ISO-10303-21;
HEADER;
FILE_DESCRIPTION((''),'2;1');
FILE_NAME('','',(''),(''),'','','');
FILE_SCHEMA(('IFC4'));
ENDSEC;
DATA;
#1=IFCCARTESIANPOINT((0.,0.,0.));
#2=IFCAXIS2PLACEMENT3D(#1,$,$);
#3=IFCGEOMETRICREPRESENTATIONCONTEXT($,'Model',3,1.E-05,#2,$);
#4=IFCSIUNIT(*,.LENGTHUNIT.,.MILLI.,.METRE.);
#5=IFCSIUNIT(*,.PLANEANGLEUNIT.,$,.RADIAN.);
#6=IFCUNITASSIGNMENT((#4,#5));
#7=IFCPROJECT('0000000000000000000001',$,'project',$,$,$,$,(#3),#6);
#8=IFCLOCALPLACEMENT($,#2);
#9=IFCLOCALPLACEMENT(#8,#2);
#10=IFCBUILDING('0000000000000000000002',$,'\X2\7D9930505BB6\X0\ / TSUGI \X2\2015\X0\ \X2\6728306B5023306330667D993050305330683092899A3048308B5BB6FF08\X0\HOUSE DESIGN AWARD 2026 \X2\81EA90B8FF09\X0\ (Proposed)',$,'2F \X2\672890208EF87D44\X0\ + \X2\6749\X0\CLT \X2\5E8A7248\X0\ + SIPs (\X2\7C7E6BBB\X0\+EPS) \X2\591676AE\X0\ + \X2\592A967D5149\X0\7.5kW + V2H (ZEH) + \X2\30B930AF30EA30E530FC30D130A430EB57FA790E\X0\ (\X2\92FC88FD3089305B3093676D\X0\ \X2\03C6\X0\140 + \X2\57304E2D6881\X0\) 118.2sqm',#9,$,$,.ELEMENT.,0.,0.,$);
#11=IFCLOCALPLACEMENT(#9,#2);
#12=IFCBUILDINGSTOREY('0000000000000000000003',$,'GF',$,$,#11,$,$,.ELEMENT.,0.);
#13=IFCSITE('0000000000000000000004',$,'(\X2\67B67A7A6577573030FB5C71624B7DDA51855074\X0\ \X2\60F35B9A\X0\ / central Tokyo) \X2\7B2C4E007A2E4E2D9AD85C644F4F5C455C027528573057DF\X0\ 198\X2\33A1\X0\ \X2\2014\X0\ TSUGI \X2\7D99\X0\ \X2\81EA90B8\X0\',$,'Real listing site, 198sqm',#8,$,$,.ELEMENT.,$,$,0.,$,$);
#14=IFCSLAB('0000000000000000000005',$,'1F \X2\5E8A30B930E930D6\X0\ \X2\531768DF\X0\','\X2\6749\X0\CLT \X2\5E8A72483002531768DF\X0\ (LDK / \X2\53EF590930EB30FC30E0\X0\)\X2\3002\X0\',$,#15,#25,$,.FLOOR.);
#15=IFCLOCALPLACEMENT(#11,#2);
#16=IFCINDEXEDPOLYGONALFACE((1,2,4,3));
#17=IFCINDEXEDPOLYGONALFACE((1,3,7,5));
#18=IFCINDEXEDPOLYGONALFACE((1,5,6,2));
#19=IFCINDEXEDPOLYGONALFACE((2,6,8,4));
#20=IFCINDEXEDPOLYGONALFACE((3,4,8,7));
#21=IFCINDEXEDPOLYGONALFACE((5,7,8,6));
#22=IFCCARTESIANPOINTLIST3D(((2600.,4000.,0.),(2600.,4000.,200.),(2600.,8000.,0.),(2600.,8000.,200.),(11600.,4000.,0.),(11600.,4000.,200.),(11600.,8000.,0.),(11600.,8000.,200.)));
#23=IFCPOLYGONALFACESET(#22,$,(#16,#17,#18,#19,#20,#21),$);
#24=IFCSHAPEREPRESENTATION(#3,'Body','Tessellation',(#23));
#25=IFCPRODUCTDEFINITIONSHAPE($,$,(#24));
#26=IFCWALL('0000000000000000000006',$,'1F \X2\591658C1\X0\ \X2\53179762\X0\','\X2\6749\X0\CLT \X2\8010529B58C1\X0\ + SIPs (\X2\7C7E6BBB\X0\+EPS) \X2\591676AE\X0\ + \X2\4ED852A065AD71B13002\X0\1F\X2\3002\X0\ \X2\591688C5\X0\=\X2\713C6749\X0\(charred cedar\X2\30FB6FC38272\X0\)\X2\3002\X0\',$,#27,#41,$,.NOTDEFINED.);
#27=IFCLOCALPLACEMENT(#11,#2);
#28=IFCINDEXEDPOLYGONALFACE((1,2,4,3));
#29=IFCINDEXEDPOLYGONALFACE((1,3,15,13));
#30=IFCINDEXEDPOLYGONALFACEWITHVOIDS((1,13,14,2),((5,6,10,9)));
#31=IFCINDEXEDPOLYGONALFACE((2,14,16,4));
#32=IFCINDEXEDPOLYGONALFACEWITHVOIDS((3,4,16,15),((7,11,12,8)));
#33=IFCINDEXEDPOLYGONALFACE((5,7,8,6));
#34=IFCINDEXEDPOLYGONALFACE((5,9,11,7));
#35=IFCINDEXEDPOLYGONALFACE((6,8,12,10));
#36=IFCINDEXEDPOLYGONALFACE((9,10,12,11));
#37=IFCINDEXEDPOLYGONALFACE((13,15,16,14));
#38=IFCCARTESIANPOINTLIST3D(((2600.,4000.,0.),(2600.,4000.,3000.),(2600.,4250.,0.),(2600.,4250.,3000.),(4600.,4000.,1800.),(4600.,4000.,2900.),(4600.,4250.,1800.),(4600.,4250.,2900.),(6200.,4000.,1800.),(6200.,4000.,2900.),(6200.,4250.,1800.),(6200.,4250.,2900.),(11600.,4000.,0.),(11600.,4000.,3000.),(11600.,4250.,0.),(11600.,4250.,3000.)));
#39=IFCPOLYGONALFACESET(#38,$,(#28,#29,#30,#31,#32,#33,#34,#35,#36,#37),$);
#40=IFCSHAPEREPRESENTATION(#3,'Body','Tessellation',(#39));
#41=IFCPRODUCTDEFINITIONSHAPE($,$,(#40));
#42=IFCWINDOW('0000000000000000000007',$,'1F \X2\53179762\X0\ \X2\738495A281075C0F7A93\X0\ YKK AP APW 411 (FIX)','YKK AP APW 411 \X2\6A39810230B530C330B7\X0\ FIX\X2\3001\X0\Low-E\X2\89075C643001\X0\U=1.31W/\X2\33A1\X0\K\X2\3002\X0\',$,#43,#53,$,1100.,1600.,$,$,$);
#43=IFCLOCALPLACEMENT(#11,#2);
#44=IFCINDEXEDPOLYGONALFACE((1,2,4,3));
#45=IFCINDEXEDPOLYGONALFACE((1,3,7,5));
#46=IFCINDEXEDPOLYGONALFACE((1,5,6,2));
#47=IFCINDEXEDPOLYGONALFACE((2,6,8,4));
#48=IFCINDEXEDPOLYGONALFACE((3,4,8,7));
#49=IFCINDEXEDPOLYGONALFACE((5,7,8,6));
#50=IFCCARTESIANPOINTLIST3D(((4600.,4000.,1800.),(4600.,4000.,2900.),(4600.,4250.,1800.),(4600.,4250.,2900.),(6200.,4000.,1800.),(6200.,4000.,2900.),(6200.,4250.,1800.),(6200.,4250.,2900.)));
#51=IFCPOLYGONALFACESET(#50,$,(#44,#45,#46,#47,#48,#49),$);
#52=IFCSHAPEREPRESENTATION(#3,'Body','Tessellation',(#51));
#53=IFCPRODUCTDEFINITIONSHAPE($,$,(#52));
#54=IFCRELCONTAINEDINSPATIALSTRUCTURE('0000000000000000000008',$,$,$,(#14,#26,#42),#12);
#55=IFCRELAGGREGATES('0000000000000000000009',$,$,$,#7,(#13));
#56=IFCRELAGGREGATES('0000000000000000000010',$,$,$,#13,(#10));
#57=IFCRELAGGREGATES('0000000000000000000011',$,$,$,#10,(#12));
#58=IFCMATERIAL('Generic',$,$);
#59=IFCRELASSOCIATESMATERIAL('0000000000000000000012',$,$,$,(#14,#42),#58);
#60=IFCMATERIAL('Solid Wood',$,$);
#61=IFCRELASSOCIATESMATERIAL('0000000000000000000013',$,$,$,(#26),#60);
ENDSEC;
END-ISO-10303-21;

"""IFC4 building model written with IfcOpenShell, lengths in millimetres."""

from ifc_helpers import new_model, si_unit, frame, frame_2d, origin, place, context, project, spatial, rectangle, extrude, material, element, fill, save


model = new_model("IFC4")

# Units and contexts
model_context = context("Model", 3, precision=1e-05, world=origin())
ifc_project = project(units=[si_unit("LENGTHUNIT", "METRE", prefix="MILLI"), si_unit("PLANEANGLEUNIT", "RADIAN")], contexts=[model_context])

# Site, building, storey
site_placement = place(None, origin())
site = spatial("IfcSite", under=ifc_project, at=site_placement, Name="(架空敷地・山手線内側 想定 / central Tokyo) 第一種中高層住居専用地域 198㎡ — TSUGI 継 自邸", ObjectType="Real listing site, 198sqm", CompositionType="ELEMENT", RefElevation=0.0)
building_placement = place(site_placement, origin())
building = spatial("IfcBuilding", under=site, at=building_placement, Name="継ぐ家 / TSUGI ― 木に倣って継ぐことを覚える家（HOUSE DESIGN AWARD 2026 自邸） (Proposed)", ObjectType="2F 木造軸組 + 杉CLT 床版 + SIPs (籾殻+EPS) 外皮 + 太陽光7.5kW + V2H (ZEH) + スクリューパイル基礎 (鋼製らせん杭 φ140 + 地中梁) 118.2sqm", CompositionType="ELEMENT", ElevationOfRefHeight=0.0, ElevationOfTerrain=0.0)
storey_placement = place(building_placement, origin())
storey = spatial("IfcBuildingStorey", under=building, at=storey_placement, Name="GF", CompositionType="ELEMENT", Elevation=0.0)

# Shared definitions
ifc_material_1 = material(Name="Generic")

# Slab
slab_1_placement = place(storey_placement, frame((1300.0, 2000.0, 0.0)))
element("IfcSlab", 1, at=slab_1_placement, inside=storey, material=ifc_material_1, Name="1F 床スラブ 北棟", Description="杉CLT 床版。北棟 (LDK / 可変ルーム)。", PredefinedType="FLOOR", context=model_context, shape_type="SweptSolid", body=[
    extrude(rectangle(XDim=9000.0, YDim=4000.0, at=frame_2d((4500.0, 2000.0))), frame((1300.0, 2000.0, 0.0)), (0.0, 0.0, 1.0), 200.0),
])

# Wall, opening, window
ifc_material_2 = material(Name="Solid Wood")
wall_1_placement = place(storey_placement, frame((1300.0, 2000.0, 0.0)))
wall_1 = element("IfcWall", 2, at=wall_1_placement, inside=storey, material=ifc_material_2, Name="1F 外壁 北面", Description="杉CLT 耐力壁 + SIPs (籾殻+EPS) 外皮 + 付加断熱。1F。 外装=焼杉(charred cedar・濃色)。", PredefinedType="NOTDEFINED", context=model_context, shape_type="SweptSolid", body=[
    extrude(rectangle(XDim=9000.0, YDim=250.0, at=frame_2d((4500.0, 125.0))), frame((1300.0, 2000.0, 0.0)), (0.0, 0.0, 1.0), 3000.0),
])
opening_placement = place(storey_placement, frame((2300.0, 2000.0, 900.0)))
opening = element("IfcOpeningElement", 3, at=opening_placement, cuts=wall_1, PredefinedType="NOTDEFINED", context=model_context, shape_type="SweptSolid", body=[
    extrude(rectangle(XDim=1600.0, YDim=250.0, at=frame_2d((800.0, 125.0))), frame((2300.0, 2000.0, 900.0)), (0.0, 0.0, 1.0), 1100.0),
])
window_placement = place(storey_placement, frame((2300.0, 2000.0, 900.0)))
window = element("IfcWindow", 4, at=window_placement, inside=storey, material=ifc_material_1, Name="1F 北面 玄関脇小窓 YKK AP APW 411 (FIX)", Description="YKK AP APW 411 樹脂サッシ FIX、Low-E複層、U=1.31W/㎡K。", OverallHeight=1100.0, OverallWidth=1600.0, context=model_context, shape_type="SweptSolid", body=[
    extrude(rectangle(XDim=1600.0, YDim=250.0, at=frame_2d((800.0, 125.0))), frame((2300.0, 2000.0, 900.0)), (0.0, 0.0, 1.0), 1100.0),
])
fill(opening, window)

save(model, "model.ifc")
